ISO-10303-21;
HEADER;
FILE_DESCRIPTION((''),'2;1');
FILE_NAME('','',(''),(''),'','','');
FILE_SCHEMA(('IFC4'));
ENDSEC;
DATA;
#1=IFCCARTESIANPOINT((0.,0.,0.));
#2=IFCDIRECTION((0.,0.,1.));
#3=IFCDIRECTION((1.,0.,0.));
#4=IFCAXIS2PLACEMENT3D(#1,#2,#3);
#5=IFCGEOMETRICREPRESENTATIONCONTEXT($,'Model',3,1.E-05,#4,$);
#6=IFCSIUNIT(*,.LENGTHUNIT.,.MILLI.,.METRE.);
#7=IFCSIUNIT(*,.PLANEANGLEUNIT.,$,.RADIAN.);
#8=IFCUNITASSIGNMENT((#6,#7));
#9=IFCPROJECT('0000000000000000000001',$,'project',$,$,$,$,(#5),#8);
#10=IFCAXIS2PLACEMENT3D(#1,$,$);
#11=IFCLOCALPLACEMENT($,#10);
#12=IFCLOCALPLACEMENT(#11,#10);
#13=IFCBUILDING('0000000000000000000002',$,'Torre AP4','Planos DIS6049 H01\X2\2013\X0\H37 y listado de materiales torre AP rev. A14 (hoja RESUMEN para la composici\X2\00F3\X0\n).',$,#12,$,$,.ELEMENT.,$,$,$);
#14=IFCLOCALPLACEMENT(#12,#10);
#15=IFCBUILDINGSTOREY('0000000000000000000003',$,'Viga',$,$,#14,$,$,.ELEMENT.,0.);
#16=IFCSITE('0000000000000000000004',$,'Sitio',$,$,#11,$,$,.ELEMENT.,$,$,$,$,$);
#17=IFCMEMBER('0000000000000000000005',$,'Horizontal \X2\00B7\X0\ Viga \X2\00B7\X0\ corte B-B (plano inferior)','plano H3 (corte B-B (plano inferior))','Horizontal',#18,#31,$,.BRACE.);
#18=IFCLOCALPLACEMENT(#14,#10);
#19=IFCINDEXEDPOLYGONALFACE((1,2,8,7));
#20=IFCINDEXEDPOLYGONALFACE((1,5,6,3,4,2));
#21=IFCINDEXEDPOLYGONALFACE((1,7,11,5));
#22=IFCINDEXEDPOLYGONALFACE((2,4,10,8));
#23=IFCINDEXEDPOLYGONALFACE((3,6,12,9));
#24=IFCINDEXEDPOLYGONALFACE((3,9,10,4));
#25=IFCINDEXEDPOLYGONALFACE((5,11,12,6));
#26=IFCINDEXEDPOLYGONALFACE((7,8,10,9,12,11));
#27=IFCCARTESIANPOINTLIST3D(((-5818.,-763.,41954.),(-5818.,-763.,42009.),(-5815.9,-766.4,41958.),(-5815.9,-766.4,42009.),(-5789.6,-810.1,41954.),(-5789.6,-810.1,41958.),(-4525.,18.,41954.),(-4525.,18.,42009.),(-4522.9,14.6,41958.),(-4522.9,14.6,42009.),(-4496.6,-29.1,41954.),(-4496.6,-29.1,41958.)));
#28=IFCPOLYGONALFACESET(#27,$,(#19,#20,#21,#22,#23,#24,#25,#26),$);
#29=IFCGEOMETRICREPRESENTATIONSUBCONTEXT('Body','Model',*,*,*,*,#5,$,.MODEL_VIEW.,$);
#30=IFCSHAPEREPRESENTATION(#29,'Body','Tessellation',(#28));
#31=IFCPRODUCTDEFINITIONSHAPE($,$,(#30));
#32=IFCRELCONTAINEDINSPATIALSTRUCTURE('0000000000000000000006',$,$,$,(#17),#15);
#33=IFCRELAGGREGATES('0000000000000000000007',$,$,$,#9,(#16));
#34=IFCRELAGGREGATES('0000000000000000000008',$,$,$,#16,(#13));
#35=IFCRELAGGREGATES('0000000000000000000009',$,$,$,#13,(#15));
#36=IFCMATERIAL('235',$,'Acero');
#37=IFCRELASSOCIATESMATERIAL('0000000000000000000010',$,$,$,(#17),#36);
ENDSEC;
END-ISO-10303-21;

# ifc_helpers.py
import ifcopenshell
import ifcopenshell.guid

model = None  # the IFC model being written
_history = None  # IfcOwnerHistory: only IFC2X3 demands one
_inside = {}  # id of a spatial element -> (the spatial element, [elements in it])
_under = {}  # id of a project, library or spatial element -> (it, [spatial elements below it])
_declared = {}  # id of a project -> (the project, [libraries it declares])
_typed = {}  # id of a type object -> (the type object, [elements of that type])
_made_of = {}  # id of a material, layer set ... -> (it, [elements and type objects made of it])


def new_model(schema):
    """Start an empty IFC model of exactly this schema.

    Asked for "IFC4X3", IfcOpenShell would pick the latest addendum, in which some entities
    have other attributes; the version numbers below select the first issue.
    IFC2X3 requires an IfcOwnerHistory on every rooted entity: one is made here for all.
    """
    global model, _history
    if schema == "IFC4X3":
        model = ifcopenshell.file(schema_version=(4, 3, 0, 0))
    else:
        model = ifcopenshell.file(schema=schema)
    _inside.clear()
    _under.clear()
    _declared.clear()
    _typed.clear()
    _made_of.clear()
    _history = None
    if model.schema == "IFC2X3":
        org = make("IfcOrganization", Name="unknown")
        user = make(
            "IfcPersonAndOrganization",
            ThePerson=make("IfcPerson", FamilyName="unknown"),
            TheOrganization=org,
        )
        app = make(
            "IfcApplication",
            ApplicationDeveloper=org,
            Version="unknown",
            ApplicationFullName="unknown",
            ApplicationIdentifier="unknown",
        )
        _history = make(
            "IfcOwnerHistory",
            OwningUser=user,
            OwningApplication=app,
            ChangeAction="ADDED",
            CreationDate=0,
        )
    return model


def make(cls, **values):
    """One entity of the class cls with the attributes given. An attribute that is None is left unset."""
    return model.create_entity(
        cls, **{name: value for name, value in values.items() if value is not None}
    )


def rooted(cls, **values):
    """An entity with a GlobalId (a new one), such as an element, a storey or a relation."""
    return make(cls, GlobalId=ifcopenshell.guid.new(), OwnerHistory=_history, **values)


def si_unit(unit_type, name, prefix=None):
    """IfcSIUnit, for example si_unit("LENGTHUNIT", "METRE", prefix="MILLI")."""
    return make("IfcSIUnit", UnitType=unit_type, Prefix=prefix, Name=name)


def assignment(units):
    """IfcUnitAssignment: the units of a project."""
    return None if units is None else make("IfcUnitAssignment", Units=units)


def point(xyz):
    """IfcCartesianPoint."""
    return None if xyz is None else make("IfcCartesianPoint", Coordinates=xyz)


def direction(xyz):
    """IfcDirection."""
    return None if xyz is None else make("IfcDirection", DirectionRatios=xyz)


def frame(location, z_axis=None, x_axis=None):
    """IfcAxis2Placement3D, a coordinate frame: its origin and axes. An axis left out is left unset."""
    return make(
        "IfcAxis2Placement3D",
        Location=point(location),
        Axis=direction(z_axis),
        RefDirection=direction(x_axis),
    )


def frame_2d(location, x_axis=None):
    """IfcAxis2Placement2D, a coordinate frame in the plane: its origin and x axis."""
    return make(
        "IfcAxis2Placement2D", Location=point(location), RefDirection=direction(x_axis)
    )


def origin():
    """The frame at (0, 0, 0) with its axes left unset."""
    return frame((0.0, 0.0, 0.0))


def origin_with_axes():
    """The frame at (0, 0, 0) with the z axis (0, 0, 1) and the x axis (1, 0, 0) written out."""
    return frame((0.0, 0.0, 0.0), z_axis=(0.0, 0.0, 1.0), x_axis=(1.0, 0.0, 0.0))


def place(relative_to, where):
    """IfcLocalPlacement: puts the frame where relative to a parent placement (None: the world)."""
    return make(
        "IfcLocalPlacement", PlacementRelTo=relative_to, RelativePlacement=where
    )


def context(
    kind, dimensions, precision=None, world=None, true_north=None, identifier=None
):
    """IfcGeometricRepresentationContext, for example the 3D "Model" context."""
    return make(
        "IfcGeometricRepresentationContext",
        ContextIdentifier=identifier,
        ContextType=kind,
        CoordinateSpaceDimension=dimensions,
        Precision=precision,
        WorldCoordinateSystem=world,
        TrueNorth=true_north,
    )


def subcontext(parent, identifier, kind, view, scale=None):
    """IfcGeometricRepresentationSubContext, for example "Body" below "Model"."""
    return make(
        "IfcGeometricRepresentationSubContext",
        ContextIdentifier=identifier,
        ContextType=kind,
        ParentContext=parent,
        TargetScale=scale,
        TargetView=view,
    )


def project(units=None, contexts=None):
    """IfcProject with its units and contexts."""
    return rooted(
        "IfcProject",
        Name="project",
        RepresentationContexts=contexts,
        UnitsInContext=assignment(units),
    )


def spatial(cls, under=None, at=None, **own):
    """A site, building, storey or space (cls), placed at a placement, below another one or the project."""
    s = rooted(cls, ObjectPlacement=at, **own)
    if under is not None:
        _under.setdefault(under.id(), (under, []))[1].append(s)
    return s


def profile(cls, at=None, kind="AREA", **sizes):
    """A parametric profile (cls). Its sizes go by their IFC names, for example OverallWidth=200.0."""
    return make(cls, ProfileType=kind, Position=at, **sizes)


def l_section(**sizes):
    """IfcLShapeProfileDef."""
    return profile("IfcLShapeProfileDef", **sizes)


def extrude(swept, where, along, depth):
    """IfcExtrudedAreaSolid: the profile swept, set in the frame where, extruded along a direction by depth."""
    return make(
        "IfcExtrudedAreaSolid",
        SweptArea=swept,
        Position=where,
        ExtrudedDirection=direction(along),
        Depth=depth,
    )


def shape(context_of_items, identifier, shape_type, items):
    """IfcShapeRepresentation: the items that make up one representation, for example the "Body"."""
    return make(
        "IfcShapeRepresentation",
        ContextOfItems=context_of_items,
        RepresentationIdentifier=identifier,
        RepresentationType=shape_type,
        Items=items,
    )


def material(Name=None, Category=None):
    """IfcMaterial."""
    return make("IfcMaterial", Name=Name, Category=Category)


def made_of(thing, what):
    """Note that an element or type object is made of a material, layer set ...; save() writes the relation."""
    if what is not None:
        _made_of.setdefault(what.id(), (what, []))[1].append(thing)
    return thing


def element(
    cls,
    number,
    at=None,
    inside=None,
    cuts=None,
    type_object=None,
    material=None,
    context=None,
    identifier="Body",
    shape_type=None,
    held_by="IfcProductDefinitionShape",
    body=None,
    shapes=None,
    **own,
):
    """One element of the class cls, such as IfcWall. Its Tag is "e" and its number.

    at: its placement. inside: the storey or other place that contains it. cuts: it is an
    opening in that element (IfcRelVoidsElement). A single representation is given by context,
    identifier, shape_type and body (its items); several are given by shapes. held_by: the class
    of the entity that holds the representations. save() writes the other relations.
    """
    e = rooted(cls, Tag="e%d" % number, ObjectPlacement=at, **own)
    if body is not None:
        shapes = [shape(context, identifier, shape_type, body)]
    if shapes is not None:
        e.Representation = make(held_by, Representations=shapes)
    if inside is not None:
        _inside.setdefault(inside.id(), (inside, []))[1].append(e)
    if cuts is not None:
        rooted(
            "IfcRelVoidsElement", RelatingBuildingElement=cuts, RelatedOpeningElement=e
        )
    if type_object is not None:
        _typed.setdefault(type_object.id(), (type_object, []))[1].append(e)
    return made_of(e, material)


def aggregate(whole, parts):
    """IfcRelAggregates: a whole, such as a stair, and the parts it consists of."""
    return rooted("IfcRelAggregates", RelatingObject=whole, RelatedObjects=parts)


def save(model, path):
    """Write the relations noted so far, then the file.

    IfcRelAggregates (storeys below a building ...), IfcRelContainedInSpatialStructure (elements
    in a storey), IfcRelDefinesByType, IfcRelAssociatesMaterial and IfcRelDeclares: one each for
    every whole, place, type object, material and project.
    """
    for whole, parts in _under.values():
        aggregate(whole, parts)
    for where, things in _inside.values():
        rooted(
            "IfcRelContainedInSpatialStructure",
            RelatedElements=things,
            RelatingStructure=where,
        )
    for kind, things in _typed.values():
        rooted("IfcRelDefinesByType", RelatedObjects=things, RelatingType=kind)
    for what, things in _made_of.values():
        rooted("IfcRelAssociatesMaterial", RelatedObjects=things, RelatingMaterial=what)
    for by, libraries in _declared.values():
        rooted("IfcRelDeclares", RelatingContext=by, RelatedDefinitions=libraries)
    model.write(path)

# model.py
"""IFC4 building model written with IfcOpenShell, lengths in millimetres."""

from ifc_helpers import new_model, si_unit, frame, frame_2d, origin, origin_with_axes, place, context, subcontext, project, spatial, l_section, extrude, material, element, save


model = new_model("IFC4")

# Units and contexts
model_context = context("Model", 3, precision=1e-05, world=origin_with_axes())
body_context = subcontext(model_context, "Body", "Model", "MODEL_VIEW")
ifc_project = project(units=[si_unit("LENGTHUNIT", "METRE", prefix="MILLI"), si_unit("PLANEANGLEUNIT", "RADIAN")], contexts=[model_context])

# Site, building, storey
site_placement = place(None, origin())
site = spatial("IfcSite", under=ifc_project, at=site_placement, Name="Sitio", CompositionType="ELEMENT")
building_placement = place(site_placement, origin())
building = spatial("IfcBuilding", under=site, at=building_placement, Name="Torre AP4", Description="Planos DIS6049 H01–H37 y listado de materiales torre AP rev. A14 (hoja RESUMEN para la composición).", CompositionType="ELEMENT")
storey_placement = place(building_placement, origin())
storey = spatial("IfcBuildingStorey", under=building, at=storey_placement, Name="Viga", CompositionType="ELEMENT", Elevation=0.0)

# Member
ifc_material = material(Name="235", Category="Acero")
member_1_placement = place(storey_placement, frame((-4525.0, 18.0, 41954.0), z_axis=(-0.85597, -0.517025, 0.0), x_axis=(0.517025, -0.85597, 0.0)))
element("IfcMember", 1, at=member_1_placement, inside=storey, material=ifc_material, Name="Horizontal · Viga · corte B-B (plano inferior)", Description="plano H3 (corte B-B (plano inferior))", ObjectType="Horizontal", PredefinedType="BRACE", context=body_context, shape_type="SweptSolid", body=[
    extrude(l_section(Depth=55.0, Width=55.0, Thickness=4.0, at=frame_2d((27.5, 27.5))), None, (0.0, 0.0, 1.0), 1510.6),
])

save(model, "model.ifc")
